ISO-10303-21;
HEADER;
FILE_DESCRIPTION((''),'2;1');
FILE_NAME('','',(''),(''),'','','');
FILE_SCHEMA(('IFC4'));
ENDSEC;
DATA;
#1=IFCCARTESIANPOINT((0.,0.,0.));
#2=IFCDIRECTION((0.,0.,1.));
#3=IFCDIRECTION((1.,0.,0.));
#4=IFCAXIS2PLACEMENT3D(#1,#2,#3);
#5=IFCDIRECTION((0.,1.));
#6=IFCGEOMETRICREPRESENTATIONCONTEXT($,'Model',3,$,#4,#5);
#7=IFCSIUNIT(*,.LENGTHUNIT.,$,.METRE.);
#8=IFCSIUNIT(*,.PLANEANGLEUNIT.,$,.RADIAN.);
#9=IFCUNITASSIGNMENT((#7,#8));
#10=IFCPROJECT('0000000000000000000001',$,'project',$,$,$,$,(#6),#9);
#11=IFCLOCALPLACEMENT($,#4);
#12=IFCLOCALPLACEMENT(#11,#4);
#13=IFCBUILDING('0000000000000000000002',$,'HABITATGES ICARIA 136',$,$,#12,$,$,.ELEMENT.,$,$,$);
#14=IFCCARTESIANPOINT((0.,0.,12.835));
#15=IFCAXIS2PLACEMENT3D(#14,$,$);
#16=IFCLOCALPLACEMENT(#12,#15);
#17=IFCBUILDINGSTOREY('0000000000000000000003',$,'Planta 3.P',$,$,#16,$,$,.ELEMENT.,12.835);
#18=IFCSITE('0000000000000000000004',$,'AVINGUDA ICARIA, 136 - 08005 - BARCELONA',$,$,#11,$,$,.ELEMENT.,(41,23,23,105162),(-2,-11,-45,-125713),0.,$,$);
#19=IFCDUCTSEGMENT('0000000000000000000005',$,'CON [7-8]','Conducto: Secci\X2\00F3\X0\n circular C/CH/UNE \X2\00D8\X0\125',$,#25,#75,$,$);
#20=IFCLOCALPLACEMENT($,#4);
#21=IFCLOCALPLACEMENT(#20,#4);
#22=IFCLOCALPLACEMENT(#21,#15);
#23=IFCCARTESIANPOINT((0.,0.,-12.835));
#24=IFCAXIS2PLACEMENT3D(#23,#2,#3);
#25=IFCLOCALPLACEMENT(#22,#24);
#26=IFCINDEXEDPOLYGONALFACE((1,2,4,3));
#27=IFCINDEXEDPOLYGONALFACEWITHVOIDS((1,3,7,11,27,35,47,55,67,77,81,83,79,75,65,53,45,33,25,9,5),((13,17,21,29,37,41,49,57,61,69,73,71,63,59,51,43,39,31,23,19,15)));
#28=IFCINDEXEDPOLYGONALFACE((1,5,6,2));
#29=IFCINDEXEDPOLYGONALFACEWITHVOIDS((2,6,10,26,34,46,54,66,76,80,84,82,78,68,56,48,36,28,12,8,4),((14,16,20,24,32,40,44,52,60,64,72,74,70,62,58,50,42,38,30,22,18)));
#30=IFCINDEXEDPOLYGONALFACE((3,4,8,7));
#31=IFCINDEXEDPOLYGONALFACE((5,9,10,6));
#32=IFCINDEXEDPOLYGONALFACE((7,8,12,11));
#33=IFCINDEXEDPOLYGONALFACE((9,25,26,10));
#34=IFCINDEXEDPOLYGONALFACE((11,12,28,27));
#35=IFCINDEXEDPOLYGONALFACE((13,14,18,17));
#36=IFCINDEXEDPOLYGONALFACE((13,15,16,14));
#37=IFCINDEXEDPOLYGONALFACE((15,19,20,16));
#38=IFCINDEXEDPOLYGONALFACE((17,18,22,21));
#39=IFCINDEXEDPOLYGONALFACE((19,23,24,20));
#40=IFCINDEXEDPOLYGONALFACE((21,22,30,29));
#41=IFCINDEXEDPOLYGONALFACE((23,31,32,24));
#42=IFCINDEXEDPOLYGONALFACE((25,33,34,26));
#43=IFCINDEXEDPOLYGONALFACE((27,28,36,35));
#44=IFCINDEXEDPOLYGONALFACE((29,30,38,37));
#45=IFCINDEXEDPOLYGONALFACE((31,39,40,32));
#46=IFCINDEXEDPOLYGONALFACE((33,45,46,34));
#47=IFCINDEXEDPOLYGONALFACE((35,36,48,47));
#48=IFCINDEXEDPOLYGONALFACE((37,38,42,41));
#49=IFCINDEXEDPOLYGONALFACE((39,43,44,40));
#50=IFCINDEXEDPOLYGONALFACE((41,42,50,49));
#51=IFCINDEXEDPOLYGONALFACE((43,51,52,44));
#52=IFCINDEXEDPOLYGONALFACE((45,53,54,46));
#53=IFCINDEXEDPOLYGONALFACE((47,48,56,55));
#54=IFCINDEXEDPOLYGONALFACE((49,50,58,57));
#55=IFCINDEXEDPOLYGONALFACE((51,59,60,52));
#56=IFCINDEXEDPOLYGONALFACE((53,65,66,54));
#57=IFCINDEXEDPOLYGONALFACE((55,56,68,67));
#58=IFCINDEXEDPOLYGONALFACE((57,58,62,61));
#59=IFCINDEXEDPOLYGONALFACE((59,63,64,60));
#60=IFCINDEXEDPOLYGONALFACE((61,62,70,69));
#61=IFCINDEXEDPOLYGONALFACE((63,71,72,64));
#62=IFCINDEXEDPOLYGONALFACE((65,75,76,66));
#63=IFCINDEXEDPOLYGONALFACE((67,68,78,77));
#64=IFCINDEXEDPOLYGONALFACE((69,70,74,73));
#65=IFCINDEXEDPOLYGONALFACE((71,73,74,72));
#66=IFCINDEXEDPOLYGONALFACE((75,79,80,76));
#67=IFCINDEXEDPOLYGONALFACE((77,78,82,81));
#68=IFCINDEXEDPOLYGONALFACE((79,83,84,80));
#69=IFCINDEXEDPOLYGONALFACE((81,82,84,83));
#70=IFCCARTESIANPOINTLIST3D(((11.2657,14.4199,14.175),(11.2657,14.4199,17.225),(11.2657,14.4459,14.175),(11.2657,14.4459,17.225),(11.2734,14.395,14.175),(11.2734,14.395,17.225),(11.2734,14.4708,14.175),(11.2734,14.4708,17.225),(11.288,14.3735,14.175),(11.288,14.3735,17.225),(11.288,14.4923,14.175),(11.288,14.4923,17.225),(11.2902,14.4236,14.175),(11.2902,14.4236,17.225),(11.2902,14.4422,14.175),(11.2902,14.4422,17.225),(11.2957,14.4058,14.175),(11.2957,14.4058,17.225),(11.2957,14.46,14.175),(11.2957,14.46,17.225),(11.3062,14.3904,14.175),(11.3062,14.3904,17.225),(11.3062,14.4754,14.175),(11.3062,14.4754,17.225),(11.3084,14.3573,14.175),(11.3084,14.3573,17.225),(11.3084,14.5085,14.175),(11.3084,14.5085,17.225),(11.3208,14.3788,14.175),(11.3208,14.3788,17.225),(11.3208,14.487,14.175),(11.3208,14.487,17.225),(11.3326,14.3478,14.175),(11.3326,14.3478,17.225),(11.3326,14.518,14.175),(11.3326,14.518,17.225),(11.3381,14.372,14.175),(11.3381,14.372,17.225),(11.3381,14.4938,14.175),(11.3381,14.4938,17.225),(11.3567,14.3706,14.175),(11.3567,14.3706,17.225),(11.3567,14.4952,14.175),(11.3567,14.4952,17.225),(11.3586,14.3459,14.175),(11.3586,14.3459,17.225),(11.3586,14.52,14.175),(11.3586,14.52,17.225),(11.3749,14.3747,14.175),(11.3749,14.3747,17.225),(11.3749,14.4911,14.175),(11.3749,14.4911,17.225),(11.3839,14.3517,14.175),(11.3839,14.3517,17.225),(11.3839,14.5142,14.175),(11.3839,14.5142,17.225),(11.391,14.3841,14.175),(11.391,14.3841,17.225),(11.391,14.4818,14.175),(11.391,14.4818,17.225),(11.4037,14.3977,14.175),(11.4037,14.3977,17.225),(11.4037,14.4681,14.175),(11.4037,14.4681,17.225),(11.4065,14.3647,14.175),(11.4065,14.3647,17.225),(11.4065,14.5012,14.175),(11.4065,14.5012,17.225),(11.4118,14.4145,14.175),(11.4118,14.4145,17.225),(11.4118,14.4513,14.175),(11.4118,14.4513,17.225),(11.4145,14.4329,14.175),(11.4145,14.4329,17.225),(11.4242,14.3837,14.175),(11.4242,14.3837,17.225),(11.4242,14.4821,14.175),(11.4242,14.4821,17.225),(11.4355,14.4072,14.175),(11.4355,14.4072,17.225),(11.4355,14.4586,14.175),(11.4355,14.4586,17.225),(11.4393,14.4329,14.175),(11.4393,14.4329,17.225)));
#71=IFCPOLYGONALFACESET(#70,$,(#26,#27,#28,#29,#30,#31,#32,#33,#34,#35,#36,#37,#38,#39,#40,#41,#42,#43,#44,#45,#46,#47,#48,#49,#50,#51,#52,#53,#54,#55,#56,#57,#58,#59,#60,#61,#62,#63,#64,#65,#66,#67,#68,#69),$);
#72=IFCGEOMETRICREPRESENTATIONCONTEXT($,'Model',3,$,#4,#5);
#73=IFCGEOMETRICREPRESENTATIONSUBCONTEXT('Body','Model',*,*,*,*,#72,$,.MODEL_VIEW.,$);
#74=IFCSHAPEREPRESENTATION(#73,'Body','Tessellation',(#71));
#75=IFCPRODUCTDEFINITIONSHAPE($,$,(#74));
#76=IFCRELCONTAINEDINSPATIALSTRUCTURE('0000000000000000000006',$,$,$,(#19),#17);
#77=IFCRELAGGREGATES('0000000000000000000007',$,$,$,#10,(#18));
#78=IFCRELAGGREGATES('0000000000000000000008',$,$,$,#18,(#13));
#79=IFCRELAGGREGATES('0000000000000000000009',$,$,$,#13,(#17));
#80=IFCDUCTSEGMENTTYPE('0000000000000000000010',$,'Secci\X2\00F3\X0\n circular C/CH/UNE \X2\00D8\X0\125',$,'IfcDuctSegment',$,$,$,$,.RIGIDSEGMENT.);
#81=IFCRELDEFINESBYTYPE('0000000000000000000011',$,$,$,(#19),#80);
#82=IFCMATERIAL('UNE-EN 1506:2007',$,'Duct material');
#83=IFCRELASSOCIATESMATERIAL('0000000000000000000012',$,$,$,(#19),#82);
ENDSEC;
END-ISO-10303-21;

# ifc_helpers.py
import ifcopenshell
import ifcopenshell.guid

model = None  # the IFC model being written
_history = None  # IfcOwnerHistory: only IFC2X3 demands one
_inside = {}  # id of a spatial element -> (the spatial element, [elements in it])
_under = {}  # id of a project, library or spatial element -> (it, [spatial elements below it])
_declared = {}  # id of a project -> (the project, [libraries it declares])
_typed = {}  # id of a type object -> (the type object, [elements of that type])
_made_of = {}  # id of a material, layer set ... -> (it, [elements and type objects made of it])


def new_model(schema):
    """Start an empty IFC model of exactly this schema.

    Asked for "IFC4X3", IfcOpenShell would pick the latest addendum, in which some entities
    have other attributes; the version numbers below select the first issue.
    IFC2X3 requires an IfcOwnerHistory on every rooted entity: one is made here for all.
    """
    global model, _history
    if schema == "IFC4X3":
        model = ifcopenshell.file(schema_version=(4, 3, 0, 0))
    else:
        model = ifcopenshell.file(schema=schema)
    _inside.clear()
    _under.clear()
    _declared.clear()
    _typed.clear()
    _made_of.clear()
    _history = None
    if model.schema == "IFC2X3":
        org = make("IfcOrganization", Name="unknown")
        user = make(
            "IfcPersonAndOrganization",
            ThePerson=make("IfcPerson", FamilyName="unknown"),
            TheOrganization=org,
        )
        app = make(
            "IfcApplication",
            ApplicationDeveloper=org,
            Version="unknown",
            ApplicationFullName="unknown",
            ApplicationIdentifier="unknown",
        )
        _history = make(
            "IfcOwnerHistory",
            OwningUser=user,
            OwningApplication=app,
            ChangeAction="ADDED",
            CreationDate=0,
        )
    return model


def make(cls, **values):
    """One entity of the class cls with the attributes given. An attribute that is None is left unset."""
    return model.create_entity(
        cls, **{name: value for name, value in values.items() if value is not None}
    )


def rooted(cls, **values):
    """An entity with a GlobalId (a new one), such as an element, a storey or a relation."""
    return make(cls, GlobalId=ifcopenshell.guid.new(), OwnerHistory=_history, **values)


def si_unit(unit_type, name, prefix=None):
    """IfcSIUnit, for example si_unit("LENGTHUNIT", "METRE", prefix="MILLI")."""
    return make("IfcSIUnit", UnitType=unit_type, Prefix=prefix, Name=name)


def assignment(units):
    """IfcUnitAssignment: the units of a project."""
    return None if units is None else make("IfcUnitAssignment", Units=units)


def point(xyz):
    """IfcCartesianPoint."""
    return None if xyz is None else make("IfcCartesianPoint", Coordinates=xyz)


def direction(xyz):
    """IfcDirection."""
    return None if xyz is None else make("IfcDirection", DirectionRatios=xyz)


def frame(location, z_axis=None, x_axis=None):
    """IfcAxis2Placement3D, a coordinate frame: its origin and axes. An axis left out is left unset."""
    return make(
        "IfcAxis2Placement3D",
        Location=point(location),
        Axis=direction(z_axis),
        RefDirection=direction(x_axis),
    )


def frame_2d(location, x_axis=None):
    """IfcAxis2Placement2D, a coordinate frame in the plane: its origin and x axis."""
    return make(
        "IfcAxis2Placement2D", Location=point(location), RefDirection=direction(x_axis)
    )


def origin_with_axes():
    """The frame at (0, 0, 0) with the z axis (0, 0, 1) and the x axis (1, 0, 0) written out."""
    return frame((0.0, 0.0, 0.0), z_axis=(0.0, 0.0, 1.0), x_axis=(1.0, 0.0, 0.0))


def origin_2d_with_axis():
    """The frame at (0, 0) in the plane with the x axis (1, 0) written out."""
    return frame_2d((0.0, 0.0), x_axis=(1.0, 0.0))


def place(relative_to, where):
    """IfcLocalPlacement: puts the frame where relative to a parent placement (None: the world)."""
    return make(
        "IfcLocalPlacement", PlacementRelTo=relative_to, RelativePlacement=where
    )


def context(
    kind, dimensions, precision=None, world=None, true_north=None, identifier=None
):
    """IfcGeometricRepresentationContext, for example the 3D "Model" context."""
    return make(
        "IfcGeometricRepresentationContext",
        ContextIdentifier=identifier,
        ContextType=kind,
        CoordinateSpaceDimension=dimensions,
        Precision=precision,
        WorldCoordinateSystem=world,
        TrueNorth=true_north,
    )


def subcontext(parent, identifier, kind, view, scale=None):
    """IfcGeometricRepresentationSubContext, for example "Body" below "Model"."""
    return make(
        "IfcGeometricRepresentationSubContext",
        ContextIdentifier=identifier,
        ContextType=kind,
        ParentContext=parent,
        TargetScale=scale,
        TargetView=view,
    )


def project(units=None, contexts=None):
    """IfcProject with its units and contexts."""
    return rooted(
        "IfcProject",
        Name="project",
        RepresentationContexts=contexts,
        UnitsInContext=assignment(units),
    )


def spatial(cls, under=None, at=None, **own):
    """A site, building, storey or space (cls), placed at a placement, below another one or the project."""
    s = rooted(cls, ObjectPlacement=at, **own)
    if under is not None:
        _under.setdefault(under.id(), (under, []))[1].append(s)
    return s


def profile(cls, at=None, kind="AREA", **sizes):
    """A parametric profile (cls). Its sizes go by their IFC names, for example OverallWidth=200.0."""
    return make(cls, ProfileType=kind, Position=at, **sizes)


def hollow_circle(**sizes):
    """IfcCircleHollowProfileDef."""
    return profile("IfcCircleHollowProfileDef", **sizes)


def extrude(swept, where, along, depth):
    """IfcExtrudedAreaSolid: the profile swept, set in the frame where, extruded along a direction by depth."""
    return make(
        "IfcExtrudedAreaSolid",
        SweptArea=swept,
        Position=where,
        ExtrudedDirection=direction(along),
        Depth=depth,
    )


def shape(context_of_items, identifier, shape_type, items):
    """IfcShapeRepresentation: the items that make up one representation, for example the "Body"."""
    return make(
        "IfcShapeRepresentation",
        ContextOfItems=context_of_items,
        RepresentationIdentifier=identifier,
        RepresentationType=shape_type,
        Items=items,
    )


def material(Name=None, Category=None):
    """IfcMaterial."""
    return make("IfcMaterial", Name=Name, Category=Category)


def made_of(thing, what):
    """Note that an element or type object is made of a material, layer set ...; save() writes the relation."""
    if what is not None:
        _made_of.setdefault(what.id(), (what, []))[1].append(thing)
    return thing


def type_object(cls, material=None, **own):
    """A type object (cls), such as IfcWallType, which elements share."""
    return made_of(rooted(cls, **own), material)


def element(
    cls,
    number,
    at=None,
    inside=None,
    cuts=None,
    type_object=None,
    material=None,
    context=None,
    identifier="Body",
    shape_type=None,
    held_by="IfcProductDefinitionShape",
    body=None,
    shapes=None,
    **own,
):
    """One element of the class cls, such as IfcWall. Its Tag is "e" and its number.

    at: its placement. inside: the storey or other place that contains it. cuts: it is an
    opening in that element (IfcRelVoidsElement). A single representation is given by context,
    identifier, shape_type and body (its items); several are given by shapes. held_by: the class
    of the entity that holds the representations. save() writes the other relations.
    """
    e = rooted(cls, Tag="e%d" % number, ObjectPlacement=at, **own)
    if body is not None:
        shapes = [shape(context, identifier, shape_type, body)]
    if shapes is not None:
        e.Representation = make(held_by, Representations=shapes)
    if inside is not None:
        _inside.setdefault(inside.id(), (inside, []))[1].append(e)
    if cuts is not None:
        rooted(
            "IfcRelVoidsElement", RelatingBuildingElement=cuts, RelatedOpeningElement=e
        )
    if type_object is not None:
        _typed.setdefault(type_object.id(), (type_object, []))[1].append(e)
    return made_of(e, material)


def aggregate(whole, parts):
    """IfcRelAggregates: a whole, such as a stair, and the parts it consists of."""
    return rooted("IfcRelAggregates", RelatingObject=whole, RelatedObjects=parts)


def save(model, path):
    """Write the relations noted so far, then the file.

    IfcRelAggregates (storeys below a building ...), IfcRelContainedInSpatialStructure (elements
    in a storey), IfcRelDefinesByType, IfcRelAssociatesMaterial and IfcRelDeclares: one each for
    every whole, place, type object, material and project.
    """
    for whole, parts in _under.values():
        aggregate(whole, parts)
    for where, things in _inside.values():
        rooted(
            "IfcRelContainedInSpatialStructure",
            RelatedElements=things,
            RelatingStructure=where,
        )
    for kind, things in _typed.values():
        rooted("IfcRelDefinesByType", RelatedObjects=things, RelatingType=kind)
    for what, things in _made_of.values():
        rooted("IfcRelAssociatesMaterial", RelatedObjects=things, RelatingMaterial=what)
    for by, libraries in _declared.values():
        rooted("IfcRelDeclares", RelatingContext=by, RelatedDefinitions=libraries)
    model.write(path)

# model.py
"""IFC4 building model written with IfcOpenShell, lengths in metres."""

from ifc_helpers import new_model, si_unit, direction, frame, origin_with_axes, origin_2d_with_axis, place, context, subcontext, project, spatial, hollow_circle, extrude, material, type_object, element, save


model = new_model("IFC4")

# Units and contexts
model_context_1 = context("Model", 3, world=origin_with_axes(), true_north=direction((0.0, 1.0)))
model_context_2 = context("Model", 3, world=origin_with_axes(), true_north=direction((0.0, 1.0)))
body_context = subcontext(model_context_2, "Body", "Model", "MODEL_VIEW")
ifc_project = project(units=[si_unit("LENGTHUNIT", "METRE"), si_unit("PLANEANGLEUNIT", "RADIAN")], contexts=[model_context_1])

# Site, building, storey
site_placement = place(None, origin_with_axes())
site = spatial("IfcSite", under=ifc_project, at=site_placement, Name="AVINGUDA ICARIA, 136 - 08005 - BARCELONA", CompositionType="ELEMENT", RefLatitude=(41, 23, 23, 105162), RefLongitude=(-2, -11, -45, -125713), RefElevation=0.0)
building_placement = place(site_placement, origin_with_axes())
building = spatial("IfcBuilding", under=site, at=building_placement, Name="HABITATGES ICARIA 136", CompositionType="ELEMENT")
storey_placement = place(building_placement, frame((0.0, 0.0, 12.835)))
storey = spatial("IfcBuildingStorey", under=building, at=storey_placement, Name="Planta 3.P", CompositionType="ELEMENT", Elevation=12.835)

# Duct segment
ifc_material = material(Name="UNE-EN 1506:2007", Category="Duct material")
duct_segment_type = type_object("IfcDuctSegmentType", Name="Sección circular C/CH/UNE Ø125", ApplicableOccurrence="IfcDuctSegment", PredefinedType="RIGIDSEGMENT")
placement_1 = place(None, origin_with_axes())
placement_2 = place(placement_1, origin_with_axes())
placement_3 = place(placement_2, frame((0.0, 0.0, 12.835)))
duct_segment_placement = place(placement_3, frame((0.0, 0.0, -12.835), z_axis=(0.0, 0.0, 1.0), x_axis=(1.0, 0.0, 0.0)))
element("IfcDuctSegment", 1, at=duct_segment_placement, inside=storey, type_object=duct_segment_type, material=ifc_material, Name="CON [7-8]", Description="Conducto: Sección circular C/CH/UNE Ø125", context=body_context, shape_type="SweptSolid", body=[
    extrude(hollow_circle(Radius=0.0873, WallThickness=0.0248, at=origin_2d_with_axis()), frame((11.352, 14.4329, 17.225), z_axis=(0.0, 0.0, -1.0), x_axis=(1.0, 0.0, 0.0)), (0.0, 0.0, 1.0), 3.05),
])

save(model, "model.ifc")
